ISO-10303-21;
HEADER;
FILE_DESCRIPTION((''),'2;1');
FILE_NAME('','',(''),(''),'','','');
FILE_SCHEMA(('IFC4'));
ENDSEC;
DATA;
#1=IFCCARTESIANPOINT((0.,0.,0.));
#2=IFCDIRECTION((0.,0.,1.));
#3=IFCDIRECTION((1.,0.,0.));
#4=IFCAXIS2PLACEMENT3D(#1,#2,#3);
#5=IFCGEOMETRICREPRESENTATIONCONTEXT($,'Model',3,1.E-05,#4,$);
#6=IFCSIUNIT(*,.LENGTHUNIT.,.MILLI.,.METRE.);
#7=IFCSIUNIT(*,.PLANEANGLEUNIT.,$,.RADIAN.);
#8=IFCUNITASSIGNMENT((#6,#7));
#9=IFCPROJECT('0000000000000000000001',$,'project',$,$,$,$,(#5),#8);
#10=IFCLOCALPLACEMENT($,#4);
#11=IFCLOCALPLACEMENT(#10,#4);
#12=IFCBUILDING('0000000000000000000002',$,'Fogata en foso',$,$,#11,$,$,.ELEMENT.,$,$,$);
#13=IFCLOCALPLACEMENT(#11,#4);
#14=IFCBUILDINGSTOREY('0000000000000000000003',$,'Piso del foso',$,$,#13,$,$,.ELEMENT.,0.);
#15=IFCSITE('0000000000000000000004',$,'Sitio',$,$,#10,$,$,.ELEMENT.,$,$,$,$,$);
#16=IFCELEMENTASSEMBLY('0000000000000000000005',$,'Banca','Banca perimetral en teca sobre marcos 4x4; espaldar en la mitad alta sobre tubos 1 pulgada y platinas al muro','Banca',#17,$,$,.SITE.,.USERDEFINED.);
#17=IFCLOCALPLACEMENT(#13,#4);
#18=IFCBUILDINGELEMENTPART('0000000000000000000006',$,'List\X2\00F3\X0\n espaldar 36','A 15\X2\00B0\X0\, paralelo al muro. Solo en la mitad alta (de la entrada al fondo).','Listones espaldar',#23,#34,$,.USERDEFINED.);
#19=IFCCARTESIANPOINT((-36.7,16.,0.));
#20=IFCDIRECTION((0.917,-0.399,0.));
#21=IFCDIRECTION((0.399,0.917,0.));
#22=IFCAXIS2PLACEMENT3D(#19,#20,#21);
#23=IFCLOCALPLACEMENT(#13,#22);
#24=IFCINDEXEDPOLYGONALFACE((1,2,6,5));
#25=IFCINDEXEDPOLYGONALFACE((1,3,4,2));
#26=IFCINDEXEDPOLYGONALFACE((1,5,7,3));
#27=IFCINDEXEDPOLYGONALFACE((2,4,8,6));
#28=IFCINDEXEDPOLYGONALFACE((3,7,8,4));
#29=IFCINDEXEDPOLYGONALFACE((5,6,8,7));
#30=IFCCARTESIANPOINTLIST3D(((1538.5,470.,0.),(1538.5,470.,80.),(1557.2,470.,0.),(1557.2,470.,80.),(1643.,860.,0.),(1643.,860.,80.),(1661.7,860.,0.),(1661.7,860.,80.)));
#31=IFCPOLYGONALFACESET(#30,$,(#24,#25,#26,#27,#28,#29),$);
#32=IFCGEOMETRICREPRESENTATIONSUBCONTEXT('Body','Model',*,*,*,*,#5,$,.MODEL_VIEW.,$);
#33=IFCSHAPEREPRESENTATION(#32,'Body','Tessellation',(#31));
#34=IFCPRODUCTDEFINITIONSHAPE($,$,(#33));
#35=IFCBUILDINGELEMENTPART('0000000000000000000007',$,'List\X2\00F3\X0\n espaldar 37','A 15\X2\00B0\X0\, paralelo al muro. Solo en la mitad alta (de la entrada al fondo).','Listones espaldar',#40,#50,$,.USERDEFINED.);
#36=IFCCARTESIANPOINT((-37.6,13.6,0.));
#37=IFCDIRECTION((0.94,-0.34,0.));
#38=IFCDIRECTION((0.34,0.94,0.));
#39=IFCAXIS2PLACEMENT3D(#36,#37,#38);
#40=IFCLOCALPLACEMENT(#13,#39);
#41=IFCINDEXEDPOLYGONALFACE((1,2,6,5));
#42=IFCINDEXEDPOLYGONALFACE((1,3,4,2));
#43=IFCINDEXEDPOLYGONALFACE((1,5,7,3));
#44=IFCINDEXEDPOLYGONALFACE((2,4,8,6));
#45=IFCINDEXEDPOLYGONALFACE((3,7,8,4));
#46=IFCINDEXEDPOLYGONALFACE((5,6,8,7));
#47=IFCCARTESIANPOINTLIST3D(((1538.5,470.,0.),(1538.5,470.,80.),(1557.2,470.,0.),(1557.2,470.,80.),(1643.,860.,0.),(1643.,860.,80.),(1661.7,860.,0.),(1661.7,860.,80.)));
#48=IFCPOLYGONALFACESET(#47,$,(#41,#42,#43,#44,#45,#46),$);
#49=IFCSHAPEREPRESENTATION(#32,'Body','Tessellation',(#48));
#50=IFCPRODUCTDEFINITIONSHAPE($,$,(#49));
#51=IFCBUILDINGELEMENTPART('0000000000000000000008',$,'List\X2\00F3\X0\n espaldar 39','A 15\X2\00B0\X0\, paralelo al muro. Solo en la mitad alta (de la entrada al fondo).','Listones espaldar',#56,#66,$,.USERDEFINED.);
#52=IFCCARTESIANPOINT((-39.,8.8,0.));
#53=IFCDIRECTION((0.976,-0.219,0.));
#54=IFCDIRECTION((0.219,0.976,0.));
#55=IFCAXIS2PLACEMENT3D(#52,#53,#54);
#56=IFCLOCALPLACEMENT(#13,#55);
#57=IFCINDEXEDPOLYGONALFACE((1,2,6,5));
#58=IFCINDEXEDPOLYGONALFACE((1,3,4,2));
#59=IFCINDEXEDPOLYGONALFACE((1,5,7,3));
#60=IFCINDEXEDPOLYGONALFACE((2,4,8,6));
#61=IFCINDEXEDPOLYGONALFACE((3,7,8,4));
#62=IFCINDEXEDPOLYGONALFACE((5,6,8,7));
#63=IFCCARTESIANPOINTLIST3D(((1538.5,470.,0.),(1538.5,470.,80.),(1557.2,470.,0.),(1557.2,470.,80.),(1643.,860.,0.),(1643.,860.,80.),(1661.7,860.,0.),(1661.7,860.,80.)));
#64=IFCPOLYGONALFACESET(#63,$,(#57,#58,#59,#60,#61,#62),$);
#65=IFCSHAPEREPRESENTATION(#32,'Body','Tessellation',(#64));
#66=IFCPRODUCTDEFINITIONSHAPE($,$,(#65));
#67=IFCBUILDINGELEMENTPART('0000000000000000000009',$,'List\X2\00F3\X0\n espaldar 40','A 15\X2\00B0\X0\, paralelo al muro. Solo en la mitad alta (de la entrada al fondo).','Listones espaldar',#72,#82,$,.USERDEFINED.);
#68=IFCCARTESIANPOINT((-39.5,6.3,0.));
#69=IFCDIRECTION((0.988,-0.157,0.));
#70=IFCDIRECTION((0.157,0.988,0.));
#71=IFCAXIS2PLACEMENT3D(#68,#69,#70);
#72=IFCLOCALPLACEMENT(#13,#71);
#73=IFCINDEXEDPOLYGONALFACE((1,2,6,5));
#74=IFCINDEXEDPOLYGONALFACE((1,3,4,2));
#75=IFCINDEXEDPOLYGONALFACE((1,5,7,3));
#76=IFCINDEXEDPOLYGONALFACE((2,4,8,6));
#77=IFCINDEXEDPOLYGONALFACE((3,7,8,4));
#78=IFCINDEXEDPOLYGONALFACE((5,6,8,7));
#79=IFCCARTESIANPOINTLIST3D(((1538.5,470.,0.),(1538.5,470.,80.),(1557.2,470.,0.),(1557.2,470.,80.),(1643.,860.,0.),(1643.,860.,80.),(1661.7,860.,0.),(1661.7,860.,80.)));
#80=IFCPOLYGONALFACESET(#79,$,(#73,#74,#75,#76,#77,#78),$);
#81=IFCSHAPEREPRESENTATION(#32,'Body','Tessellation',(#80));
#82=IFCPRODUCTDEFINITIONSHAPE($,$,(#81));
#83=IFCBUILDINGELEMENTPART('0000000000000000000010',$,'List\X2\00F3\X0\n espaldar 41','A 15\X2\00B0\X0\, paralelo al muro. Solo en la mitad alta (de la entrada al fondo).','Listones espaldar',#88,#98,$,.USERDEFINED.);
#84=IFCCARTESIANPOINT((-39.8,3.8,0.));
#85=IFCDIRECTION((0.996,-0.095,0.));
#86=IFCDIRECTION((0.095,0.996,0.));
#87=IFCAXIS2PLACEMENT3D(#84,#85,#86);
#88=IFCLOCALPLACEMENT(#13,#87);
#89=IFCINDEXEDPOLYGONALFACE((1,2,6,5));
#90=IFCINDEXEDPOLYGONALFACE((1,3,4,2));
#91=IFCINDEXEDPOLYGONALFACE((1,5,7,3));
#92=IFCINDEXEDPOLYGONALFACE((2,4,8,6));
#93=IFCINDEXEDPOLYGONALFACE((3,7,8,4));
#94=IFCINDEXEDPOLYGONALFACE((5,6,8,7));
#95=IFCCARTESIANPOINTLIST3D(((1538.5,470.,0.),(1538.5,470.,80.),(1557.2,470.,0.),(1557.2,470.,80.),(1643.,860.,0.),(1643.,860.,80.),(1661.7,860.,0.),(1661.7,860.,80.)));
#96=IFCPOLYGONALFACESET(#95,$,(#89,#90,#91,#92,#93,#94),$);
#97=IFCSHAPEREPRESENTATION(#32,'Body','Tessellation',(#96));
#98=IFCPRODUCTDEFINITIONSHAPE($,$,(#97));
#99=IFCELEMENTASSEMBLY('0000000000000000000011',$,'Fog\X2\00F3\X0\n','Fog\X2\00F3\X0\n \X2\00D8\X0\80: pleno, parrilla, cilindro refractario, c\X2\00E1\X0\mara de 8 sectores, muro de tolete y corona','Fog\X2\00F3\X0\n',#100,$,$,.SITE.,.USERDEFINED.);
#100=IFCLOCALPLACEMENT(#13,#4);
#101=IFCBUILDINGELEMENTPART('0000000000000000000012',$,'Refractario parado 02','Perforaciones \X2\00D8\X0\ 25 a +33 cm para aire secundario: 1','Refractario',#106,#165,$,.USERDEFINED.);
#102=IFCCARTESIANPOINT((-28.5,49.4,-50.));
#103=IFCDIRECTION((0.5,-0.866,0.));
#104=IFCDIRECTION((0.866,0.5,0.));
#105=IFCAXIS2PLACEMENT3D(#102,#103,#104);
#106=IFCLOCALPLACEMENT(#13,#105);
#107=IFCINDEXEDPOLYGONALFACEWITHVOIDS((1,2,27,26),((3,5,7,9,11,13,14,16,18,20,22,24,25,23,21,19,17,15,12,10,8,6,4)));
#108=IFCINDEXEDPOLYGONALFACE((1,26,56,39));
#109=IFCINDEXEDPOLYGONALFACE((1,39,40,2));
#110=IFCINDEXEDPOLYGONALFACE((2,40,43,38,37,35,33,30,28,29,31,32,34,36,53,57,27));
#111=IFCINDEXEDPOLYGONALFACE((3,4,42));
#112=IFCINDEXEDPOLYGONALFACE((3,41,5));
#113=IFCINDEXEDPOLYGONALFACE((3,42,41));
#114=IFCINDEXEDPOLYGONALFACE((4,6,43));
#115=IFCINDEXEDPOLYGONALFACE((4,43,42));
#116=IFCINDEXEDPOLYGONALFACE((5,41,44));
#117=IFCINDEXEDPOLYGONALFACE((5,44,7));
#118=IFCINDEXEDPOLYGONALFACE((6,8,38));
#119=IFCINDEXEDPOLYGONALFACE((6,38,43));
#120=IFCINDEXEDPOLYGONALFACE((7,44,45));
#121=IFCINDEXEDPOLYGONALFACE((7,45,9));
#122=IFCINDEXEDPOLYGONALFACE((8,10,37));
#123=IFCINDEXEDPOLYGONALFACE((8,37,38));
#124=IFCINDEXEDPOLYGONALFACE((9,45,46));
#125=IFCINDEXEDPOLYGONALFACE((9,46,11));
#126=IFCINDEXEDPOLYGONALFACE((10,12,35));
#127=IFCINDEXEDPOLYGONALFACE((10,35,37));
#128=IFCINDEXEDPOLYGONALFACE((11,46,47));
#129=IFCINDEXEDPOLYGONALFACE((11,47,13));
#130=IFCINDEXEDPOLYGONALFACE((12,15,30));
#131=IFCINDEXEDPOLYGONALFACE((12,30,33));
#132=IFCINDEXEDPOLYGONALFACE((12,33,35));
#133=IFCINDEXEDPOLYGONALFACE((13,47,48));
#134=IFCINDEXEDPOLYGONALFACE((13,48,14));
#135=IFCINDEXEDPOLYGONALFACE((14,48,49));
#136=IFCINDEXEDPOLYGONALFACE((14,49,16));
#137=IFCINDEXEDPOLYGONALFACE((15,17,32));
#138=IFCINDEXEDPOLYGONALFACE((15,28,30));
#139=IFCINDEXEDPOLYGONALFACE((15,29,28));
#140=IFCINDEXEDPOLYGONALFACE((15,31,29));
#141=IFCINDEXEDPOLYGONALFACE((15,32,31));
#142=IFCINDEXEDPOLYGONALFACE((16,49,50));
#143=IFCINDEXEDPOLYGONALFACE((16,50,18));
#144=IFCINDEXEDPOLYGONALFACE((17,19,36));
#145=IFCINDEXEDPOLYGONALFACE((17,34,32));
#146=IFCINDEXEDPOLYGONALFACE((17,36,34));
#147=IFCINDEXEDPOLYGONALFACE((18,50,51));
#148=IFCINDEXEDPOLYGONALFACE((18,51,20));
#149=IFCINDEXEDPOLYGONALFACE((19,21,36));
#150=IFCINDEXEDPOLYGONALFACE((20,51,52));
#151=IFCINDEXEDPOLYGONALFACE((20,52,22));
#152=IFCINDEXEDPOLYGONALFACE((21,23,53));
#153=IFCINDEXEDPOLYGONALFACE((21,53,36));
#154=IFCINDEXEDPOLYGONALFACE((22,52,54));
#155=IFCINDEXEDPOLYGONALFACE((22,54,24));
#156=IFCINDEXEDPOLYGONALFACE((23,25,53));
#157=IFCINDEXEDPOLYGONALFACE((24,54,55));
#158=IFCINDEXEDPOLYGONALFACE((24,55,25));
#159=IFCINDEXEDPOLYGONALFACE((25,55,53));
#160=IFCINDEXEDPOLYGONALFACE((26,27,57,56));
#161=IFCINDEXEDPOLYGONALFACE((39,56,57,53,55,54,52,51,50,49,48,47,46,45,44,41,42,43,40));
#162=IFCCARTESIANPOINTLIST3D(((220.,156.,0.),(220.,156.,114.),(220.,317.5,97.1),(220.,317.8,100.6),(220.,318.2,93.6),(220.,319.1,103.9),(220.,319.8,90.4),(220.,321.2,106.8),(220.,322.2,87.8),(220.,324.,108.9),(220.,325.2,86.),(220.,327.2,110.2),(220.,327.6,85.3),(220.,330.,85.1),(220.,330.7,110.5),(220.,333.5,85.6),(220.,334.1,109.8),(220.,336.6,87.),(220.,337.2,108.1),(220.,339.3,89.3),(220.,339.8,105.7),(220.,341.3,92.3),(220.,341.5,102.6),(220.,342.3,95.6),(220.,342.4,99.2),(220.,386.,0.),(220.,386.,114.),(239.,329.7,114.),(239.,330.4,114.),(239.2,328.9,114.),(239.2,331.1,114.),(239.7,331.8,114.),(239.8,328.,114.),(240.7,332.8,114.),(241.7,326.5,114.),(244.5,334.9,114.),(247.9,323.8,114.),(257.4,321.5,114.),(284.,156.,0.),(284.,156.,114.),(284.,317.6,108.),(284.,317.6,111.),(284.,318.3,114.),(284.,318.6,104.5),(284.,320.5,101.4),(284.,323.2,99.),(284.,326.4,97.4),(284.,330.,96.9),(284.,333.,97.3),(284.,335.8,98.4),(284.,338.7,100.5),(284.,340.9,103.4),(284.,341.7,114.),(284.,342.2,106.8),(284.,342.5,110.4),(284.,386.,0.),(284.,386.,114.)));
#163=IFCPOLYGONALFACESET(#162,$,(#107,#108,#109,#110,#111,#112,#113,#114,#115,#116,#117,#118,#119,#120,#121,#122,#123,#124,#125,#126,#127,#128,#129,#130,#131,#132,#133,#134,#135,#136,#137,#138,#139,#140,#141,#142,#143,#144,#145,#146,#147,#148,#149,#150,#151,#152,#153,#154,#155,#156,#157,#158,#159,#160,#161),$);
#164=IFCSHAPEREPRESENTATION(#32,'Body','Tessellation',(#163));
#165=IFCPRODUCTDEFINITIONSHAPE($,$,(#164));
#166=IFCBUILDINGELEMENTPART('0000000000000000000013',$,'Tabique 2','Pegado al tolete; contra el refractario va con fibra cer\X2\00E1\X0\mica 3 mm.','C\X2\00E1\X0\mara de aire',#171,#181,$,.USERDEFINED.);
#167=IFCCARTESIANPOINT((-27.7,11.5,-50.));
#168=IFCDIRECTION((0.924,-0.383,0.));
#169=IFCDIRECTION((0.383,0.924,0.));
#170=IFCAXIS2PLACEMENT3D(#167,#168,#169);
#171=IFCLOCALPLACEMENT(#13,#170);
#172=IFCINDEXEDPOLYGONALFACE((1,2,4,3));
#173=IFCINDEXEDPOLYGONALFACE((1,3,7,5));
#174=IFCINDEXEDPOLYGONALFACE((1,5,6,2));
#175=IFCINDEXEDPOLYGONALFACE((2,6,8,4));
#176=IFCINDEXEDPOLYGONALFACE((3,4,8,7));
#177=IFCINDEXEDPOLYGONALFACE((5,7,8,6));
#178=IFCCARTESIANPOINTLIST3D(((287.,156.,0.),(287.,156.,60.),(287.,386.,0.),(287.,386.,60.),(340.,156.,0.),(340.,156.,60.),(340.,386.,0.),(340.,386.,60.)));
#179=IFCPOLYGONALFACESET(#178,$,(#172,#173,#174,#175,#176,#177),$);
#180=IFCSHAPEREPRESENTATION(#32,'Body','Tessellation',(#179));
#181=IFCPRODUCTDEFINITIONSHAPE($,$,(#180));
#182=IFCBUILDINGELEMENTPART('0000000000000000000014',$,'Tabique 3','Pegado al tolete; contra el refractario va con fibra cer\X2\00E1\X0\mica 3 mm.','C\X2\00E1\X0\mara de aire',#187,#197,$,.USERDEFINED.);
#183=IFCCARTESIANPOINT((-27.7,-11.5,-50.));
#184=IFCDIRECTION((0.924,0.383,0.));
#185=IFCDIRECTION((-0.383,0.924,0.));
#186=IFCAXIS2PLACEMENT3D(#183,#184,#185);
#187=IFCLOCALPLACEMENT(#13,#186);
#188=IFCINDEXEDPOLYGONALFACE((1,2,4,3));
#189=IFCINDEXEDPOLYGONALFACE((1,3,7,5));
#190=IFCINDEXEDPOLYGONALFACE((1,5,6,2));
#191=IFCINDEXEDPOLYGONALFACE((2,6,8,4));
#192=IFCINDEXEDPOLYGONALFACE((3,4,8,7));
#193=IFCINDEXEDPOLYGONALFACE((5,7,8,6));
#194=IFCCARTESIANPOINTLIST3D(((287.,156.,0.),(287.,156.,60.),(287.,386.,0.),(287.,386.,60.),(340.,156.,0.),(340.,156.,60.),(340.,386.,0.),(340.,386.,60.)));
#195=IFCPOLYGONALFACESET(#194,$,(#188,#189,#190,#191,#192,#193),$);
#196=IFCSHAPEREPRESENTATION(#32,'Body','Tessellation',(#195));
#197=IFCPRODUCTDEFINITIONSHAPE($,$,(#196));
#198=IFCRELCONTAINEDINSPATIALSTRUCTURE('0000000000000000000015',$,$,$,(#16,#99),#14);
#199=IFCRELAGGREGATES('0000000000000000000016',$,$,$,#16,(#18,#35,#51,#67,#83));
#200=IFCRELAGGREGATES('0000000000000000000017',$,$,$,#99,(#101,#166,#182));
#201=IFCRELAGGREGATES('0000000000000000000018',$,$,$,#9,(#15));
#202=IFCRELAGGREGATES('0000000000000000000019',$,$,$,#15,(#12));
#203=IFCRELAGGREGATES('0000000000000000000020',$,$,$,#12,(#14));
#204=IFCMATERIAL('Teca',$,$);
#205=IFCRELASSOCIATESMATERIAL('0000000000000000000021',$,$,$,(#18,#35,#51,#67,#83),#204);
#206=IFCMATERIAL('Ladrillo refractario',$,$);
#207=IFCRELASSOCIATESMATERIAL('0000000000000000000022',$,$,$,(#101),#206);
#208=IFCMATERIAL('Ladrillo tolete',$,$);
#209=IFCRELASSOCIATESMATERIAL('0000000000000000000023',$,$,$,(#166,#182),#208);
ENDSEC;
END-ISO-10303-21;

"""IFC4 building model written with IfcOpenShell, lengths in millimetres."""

from ifc_helpers import new_model, si_unit, frame, origin_with_axes, origin_2d, place, context, subcontext, project, spatial, polyline, circle, outline, extrude, material, element, aggregate, save


model = new_model("IFC4")

# Units and contexts
model_context = context("Model", 3, precision=1e-05, world=origin_with_axes())
body_context = subcontext(model_context, "Body", "Model", "MODEL_VIEW")
ifc_project = project(units=[si_unit("LENGTHUNIT", "METRE", prefix="MILLI"), si_unit("PLANEANGLEUNIT", "RADIAN")], contexts=[model_context])

# Site, building, storey
site_placement = place(None, origin_with_axes())
site = spatial("IfcSite", under=ifc_project, at=site_placement, Name="Sitio", CompositionType="ELEMENT")
building_placement = place(site_placement, origin_with_axes())
building = spatial("IfcBuilding", under=site, at=building_placement, Name="Fogata en foso", CompositionType="ELEMENT")
storey_placement = place(building_placement, origin_with_axes())
storey = spatial("IfcBuildingStorey", under=building, at=storey_placement, Name="Piso del foso", CompositionType="ELEMENT", Elevation=0.0)

# Element assembly, building element parts
assembly_1_placement = place(storey_placement, origin_with_axes())
assembly_1 = element("IfcElementAssembly", 1, at=assembly_1_placement, inside=storey, Name="Banca", Description="Banca perimetral en teca sobre marcos 4x4; espaldar en la mitad alta sobre tubos 1 pulgada y platinas al muro", ObjectType="Banca", AssemblyPlace="SITE", PredefinedType="USERDEFINED")
ifc_material_1 = material(Name="Teca")
building_element_part_1_placement = place(storey_placement, frame((-36.7, 16.0, 0.0), z_axis=(0.917, -0.399, 0.0), x_axis=(0.399, 0.917, 0.0)))
building_element_part_1 = element("IfcBuildingElementPart", 2, at=building_element_part_1_placement, material=ifc_material_1, Name="Listón espaldar 36", Description="A 15°, paralelo al muro. Solo en la mitad alta (de la entrada al fondo).", ObjectType="Listones espaldar", PredefinedType="USERDEFINED", context=body_context, shape_type="SweptSolid", body=[
    extrude(outline(polyline([(1538.5, 470.0), (1557.2, 470.0), (1661.7, 860.0), (1643.0, 860.0), (1538.5, 470.0)])), origin_with_axes(), (0.0, 0.0, 1.0), 80.0),
])
building_element_part_2_placement = place(storey_placement, frame((-37.6, 13.6, 0.0), z_axis=(0.94, -0.34, 0.0), x_axis=(0.34, 0.94, 0.0)))
building_element_part_2 = element("IfcBuildingElementPart", 3, at=building_element_part_2_placement, material=ifc_material_1, Name="Listón espaldar 37", Description="A 15°, paralelo al muro. Solo en la mitad alta (de la entrada al fondo).", ObjectType="Listones espaldar", PredefinedType="USERDEFINED", context=body_context, shape_type="SweptSolid", body=[
    extrude(outline(polyline([(1538.5, 470.0), (1557.2, 470.0), (1661.7, 860.0), (1643.0, 860.0), (1538.5, 470.0)])), origin_with_axes(), (0.0, 0.0, 1.0), 80.0),
])
building_element_part_3_placement = place(storey_placement, frame((-39.0, 8.8, 0.0), z_axis=(0.976, -0.219, 0.0), x_axis=(0.219, 0.976, 0.0)))
building_element_part_3 = element("IfcBuildingElementPart", 4, at=building_element_part_3_placement, material=ifc_material_1, Name="Listón espaldar 39", Description="A 15°, paralelo al muro. Solo en la mitad alta (de la entrada al fondo).", ObjectType="Listones espaldar", PredefinedType="USERDEFINED", context=body_context, shape_type="SweptSolid", body=[
    extrude(outline(polyline([(1538.5, 470.0), (1557.2, 470.0), (1661.7, 860.0), (1643.0, 860.0), (1538.5, 470.0)])), origin_with_axes(), (0.0, 0.0, 1.0), 80.0),
])
building_element_part_4_placement = place(storey_placement, frame((-39.5, 6.3, 0.0), z_axis=(0.988, -0.157, 0.0), x_axis=(0.157, 0.988, 0.0)))
building_element_part_4 = element("IfcBuildingElementPart", 5, at=building_element_part_4_placement, material=ifc_material_1, Name="Listón espaldar 40", Description="A 15°, paralelo al muro. Solo en la mitad alta (de la entrada al fondo).", ObjectType="Listones espaldar", PredefinedType="USERDEFINED", context=body_context, shape_type="SweptSolid", body=[
    extrude(outline(polyline([(1538.5, 470.0), (1557.2, 470.0), (1661.7, 860.0), (1643.0, 860.0), (1538.5, 470.0)])), origin_with_axes(), (0.0, 0.0, 1.0), 80.0),
])
building_element_part_5_placement = place(storey_placement, frame((-39.8, 3.8, 0.0), z_axis=(0.996, -0.095, 0.0), x_axis=(0.095, 0.996, 0.0)))
building_element_part_5 = element("IfcBuildingElementPart", 6, at=building_element_part_5_placement, material=ifc_material_1, Name="Listón espaldar 41", Description="A 15°, paralelo al muro. Solo en la mitad alta (de la entrada al fondo).", ObjectType="Listones espaldar", PredefinedType="USERDEFINED", context=body_context, shape_type="SweptSolid", body=[
    extrude(outline(polyline([(1538.5, 470.0), (1557.2, 470.0), (1661.7, 860.0), (1643.0, 860.0), (1538.5, 470.0)])), origin_with_axes(), (0.0, 0.0, 1.0), 80.0),
])
aggregate(assembly_1, [building_element_part_1, building_element_part_2, building_element_part_3, building_element_part_4, building_element_part_5])

# Element assembly, building element parts, opening
assembly_2_placement = place(storey_placement, origin_with_axes())
assembly_2 = element("IfcElementAssembly", 7, at=assembly_2_placement, inside=storey, Name="Fogón", Description="Fogón Ø80: pleno, parrilla, cilindro refractario, cámara de 8 sectores, muro de tolete y corona", ObjectType="Fogón", AssemblyPlace="SITE", PredefinedType="USERDEFINED")
ifc_material_2 = material(Name="Ladrillo refractario")
building_element_part_6_placement = place(storey_placement, frame((-28.5, 49.4, -50.0), z_axis=(0.5, -0.866, 0.0), x_axis=(0.866, 0.5, 0.0)))
building_element_part_6 = element("IfcBuildingElementPart", 8, at=building_element_part_6_placement, material=ifc_material_2, Name="Refractario parado 02", Description="Perforaciones Ø 25 a +33 cm para aire secundario: 1", ObjectType="Refractario", PredefinedType="USERDEFINED", context=body_context, shape_type="SweptSolid", body=[
    extrude(outline(polyline([(220.0, 156.0), (284.0, 156.0), (284.0, 386.0), (220.0, 386.0), (220.0, 156.0)])), origin_with_axes(), (0.0, 0.0, 1.0), 114.0),
])
opening_1_placement = place(storey_placement, frame((183.8, 65.1, 280.0), z_axis=(0.943, 0.334, 0.0), x_axis=(-0.334, 0.943, 0.0)))
element("IfcOpeningElement", 9, at=opening_1_placement, cuts=building_element_part_6, PredefinedType="OPENING", context=body_context, shape_type="SweptSolid", body=[
    extrude(circle(Radius=12.5, at=origin_2d()), origin_with_axes(), (0.0, 0.0, 1.0), 110.0),
])
ifc_material_3 = material(Name="Ladrillo tolete")
building_element_part_7_placement = place(storey_placement, frame((-27.7, 11.5, -50.0), z_axis=(0.924, -0.383, 0.0), x_axis=(0.383, 0.924, 0.0)))
building_element_part_7 = element("IfcBuildingElementPart", 10, at=building_element_part_7_placement, material=ifc_material_3, Name="Tabique 2", Description="Pegado al tolete; contra el refractario va con fibra cerámica 3 mm.", ObjectType="Cámara de aire", PredefinedType="USERDEFINED", context=body_context, shape_type="SweptSolid", body=[
    extrude(outline(polyline([(287.0, 156.0), (340.0, 156.0), (340.0, 386.0), (287.0, 386.0), (287.0, 156.0)])), origin_with_axes(), (0.0, 0.0, 1.0), 60.0),
])
building_element_part_8_placement = place(storey_placement, frame((-27.7, -11.5, -50.0), z_axis=(0.924, 0.383, 0.0), x_axis=(-0.383, 0.924, 0.0)))
building_element_part_8 = element("IfcBuildingElementPart", 11, at=building_element_part_8_placement, material=ifc_material_3, Name="Tabique 3", Description="Pegado al tolete; contra el refractario va con fibra cerámica 3 mm.", ObjectType="Cámara de aire", PredefinedType="USERDEFINED", context=body_context, shape_type="SweptSolid", body=[
    extrude(outline(polyline([(287.0, 156.0), (340.0, 156.0), (340.0, 386.0), (287.0, 386.0), (287.0, 156.0)])), origin_with_axes(), (0.0, 0.0, 1.0), 60.0),
])
aggregate(assembly_2, [building_element_part_6, building_element_part_7, building_element_part_8])

save(model, "model.ifc")
